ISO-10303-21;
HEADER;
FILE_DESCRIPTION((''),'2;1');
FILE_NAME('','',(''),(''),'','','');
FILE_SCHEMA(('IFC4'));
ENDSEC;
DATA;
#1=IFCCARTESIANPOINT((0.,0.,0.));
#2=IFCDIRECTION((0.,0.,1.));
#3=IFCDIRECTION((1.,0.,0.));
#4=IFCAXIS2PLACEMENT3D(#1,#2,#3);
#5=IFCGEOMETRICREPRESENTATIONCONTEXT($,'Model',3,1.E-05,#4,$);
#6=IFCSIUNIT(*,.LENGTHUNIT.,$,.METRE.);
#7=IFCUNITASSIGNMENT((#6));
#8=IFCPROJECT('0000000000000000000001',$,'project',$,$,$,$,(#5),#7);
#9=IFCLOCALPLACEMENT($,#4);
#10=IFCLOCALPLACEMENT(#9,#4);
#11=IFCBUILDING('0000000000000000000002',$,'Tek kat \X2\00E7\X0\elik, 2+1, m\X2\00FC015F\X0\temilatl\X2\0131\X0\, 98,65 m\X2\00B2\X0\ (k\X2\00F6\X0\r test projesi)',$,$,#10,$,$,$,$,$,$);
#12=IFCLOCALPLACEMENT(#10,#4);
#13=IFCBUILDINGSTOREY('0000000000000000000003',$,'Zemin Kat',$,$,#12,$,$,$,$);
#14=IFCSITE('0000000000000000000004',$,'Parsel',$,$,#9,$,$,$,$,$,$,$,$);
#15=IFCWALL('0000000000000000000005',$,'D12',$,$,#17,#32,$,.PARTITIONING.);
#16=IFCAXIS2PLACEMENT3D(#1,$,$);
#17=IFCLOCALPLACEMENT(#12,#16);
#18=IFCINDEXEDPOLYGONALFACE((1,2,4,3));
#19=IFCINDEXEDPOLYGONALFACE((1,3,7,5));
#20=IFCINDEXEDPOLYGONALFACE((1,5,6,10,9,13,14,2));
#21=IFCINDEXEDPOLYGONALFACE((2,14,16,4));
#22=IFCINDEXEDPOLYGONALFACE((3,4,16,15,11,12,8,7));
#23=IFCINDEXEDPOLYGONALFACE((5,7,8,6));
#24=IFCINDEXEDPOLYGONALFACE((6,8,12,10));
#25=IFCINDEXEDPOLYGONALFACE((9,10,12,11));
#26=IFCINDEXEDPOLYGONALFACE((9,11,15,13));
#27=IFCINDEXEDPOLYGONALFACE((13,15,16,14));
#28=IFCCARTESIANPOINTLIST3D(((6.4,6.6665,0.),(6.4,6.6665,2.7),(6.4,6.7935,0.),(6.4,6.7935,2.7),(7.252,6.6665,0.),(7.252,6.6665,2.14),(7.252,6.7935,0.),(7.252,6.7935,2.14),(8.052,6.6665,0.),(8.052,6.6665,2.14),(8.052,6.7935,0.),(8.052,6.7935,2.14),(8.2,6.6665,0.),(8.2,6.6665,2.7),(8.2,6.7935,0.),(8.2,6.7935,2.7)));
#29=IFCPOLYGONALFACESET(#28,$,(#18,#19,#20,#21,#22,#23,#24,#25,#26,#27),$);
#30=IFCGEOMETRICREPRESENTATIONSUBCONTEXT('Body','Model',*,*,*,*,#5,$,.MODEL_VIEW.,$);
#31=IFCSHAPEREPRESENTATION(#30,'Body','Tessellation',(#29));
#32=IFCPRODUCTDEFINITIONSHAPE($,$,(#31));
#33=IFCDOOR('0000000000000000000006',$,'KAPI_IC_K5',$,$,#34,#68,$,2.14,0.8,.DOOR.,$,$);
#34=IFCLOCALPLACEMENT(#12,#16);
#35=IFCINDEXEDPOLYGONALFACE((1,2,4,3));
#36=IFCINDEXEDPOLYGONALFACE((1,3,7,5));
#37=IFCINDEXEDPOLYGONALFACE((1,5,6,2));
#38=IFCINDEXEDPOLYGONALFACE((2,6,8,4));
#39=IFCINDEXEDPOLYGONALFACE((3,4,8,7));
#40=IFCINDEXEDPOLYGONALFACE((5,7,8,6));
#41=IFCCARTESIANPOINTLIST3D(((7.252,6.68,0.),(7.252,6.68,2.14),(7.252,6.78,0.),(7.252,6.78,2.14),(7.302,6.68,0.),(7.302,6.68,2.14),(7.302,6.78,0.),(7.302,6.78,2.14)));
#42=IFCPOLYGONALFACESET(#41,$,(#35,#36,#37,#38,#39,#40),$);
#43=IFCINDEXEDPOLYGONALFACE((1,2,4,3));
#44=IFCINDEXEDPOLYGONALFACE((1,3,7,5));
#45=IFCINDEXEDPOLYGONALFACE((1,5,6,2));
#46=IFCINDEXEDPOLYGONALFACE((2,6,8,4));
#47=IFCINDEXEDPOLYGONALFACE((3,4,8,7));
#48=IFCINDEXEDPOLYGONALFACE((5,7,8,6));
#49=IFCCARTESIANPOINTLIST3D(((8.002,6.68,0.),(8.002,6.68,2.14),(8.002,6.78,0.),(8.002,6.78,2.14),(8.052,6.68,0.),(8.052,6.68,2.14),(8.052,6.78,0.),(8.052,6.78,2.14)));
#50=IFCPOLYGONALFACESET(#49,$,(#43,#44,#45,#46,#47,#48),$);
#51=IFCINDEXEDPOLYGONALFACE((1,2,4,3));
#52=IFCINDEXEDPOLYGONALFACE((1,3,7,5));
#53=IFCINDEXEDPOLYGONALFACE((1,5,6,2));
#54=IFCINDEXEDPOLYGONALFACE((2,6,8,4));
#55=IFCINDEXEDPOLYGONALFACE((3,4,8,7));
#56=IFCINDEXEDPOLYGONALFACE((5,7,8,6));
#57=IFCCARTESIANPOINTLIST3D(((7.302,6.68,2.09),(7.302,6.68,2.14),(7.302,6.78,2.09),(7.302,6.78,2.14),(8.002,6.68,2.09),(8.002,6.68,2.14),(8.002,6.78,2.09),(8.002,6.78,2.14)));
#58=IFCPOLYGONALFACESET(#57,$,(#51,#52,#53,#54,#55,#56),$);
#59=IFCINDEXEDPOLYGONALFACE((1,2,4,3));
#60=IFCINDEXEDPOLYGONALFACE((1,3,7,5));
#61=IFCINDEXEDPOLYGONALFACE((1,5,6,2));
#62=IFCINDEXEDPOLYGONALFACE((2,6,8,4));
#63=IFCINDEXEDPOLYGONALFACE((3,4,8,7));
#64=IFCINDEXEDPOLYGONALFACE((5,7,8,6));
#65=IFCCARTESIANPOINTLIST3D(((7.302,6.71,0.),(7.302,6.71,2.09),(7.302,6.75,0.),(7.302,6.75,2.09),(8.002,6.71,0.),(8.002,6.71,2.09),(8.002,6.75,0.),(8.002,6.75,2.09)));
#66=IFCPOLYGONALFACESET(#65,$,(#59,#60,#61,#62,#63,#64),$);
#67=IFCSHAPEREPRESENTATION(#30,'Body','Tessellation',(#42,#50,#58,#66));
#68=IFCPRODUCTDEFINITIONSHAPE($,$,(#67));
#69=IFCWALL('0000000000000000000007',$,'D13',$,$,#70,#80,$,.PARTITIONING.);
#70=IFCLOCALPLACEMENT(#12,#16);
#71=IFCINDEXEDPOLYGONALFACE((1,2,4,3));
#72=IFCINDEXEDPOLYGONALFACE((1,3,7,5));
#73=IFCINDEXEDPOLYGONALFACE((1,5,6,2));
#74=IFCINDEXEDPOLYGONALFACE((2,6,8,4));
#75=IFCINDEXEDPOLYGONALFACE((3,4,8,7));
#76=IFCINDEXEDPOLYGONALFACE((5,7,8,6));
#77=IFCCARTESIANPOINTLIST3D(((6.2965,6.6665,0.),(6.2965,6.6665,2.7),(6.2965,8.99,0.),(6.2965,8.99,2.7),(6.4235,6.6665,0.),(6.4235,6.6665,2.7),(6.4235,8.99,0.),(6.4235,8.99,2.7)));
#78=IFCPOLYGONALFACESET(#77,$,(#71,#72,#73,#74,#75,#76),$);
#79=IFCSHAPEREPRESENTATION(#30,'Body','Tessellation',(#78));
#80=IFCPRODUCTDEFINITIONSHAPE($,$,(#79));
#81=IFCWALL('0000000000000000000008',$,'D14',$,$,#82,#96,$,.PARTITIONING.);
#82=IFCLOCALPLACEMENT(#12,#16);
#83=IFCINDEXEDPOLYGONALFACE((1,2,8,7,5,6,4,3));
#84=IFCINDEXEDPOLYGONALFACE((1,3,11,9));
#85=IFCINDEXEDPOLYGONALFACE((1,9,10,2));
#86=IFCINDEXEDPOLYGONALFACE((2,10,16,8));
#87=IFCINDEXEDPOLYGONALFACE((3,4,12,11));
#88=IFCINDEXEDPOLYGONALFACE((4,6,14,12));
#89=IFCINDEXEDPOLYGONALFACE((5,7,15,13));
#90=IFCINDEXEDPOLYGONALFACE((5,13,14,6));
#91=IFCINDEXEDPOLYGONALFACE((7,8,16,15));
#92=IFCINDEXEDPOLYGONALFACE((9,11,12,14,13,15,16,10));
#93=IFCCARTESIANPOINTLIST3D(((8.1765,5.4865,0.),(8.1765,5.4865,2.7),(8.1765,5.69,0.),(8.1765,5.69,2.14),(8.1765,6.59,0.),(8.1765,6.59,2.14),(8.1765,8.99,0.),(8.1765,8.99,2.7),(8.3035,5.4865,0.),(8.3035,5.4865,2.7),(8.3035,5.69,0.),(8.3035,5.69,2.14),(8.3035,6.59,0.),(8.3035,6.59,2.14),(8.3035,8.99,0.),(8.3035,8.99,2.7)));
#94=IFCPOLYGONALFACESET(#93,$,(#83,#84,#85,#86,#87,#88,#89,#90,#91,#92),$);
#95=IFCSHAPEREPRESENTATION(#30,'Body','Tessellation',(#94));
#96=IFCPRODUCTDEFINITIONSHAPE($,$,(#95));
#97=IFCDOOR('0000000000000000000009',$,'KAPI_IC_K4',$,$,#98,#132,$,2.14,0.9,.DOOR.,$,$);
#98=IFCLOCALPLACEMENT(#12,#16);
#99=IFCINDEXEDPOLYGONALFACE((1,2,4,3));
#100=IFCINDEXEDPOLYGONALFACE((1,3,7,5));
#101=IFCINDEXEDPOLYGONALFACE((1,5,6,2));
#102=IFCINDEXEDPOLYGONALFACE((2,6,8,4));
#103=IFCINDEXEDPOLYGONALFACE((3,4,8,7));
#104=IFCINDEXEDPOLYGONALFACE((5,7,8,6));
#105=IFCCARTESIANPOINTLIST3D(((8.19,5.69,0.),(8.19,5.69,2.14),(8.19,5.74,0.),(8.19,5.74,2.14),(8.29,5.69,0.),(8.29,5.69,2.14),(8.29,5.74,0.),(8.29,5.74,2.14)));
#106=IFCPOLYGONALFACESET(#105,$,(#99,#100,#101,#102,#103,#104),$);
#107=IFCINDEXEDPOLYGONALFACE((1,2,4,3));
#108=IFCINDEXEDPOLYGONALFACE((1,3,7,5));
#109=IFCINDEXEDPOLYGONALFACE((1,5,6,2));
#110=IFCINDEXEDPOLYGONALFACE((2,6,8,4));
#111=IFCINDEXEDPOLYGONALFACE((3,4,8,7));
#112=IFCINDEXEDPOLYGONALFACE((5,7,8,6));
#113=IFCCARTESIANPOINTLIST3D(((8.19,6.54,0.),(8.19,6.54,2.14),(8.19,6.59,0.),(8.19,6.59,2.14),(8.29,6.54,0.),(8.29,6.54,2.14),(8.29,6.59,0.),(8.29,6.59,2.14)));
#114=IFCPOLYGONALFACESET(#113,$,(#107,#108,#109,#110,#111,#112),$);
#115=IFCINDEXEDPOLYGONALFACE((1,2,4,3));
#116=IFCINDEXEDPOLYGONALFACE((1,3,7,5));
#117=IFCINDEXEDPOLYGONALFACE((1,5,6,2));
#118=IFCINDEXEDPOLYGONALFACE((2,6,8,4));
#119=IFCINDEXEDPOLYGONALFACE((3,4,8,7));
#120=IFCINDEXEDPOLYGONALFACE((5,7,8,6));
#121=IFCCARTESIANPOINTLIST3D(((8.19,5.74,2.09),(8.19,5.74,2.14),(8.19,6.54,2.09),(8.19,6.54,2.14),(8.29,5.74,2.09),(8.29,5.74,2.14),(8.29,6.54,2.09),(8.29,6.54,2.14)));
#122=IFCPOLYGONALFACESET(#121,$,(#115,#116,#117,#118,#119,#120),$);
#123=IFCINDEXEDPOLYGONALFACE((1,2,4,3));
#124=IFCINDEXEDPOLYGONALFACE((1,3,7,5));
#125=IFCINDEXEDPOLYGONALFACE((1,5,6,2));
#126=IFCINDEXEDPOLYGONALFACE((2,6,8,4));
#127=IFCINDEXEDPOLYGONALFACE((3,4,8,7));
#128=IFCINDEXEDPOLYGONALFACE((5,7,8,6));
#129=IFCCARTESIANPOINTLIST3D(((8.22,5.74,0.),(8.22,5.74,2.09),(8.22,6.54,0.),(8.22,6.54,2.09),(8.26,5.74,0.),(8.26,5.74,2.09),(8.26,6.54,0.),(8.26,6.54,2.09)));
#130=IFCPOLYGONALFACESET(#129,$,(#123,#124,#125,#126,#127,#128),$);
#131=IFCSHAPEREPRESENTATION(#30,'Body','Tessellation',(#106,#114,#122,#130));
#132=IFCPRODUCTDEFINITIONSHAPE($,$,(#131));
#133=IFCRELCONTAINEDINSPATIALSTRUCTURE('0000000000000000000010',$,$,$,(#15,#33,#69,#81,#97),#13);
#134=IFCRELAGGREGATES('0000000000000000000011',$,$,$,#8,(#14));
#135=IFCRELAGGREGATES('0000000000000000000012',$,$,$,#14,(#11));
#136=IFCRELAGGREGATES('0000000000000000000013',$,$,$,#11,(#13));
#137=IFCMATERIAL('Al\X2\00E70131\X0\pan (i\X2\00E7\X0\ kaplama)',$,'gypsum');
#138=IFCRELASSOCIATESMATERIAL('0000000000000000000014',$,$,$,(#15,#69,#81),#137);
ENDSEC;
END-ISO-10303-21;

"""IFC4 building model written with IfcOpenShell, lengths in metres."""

from ifc_helpers import new_model, si_unit, frame, origin_with_axes, place, context, subcontext, project, spatial, line, indexed_curve, outline, extrude, material, element, fill, save


model = new_model("IFC4")

# Units and contexts
model_context = context("Model", 3, precision=1e-05, world=origin_with_axes())
body_context = subcontext(model_context, "Body", "Model", "MODEL_VIEW")
ifc_project = project(units=[si_unit("LENGTHUNIT", "METRE")], contexts=[model_context])

# Site, building, storey
site_placement = place(None, origin_with_axes())
site = spatial("IfcSite", under=ifc_project, at=site_placement, Name="Parsel")
building_placement = place(site_placement, origin_with_axes())
building = spatial("IfcBuilding", under=site, at=building_placement, Name="Tek kat çelik, 2+1, müştemilatlı, 98,65 m² (kör test projesi)")
storey_placement = place(building_placement, origin_with_axes())
storey = spatial("IfcBuildingStorey", under=building, at=storey_placement, Name="Zemin Kat")

# Shared definitions
ifc_material_1 = material(Name="Alçıpan (iç kaplama)", Category="gypsum")

# Wall, opening, door
wall_1_placement = place(storey_placement, origin_with_axes())
wall_1 = element("IfcWall", 1, at=wall_1_placement, inside=storey, material=ifc_material_1, Name="D12", PredefinedType="PARTITIONING", context=body_context, shape_type="SweptSolid", body=[
    extrude(outline(indexed_curve([(0.0, 0.0), (1.8, 0.0), (1.8, 0.127), (0.0, 0.127)], segments=[line(1, 2, 3, 4, 1)])), frame((6.4, 6.6665, 0.0), z_axis=(0.0, 0.0, 1.0), x_axis=(1.0, 0.0, 0.0)), (0.0, 0.0, 1.0), 2.7),
])
opening_1_placement = place(wall_1_placement, origin_with_axes())
opening_1 = element("IfcOpeningElement", 2, at=opening_1_placement, cuts=wall_1, PredefinedType="OPENING", context=body_context, shape_type="SweptSolid", body=[
    extrude(outline(indexed_curve([(0.0, 0.0), (0.8, 0.0), (0.8, 0.167), (0.0, 0.167)], segments=[line(1, 2, 3, 4, 1)])), frame((7.252, 6.6465, 0.0), z_axis=(0.0, 0.0, 1.0), x_axis=(1.0, 0.0, 0.0)), (0.0, 0.0, 1.0), 2.14),
])
door_1_placement = place(storey_placement, origin_with_axes())
door_1 = element("IfcDoor", 3, at=door_1_placement, inside=storey, Name="KAPI_IC_K5", OverallHeight=2.14, OverallWidth=0.8, PredefinedType="DOOR", context=body_context, shape_type="SweptSolid", body=[
    extrude(outline(indexed_curve([(0.0, 0.0), (0.05, 0.0), (0.05, 0.1), (0.0, 0.1)], segments=[line(1, 2, 3, 4, 1)])), frame((7.252, 6.68, 0.0), z_axis=(0.0, 0.0, 1.0), x_axis=(1.0, 0.0, 0.0)), (0.0, 0.0, 1.0), 2.14),
    extrude(outline(indexed_curve([(0.0, 0.0), (0.05, 0.0), (0.05, 0.1), (0.0, 0.1)], segments=[line(1, 2, 3, 4, 1)])), frame((8.002, 6.68, 0.0), z_axis=(0.0, 0.0, 1.0), x_axis=(1.0, 0.0, 0.0)), (0.0, 0.0, 1.0), 2.14),
    extrude(outline(indexed_curve([(0.0, 0.0), (0.7, 0.0), (0.7, 0.1), (0.0, 0.1)], segments=[line(1, 2, 3, 4, 1)])), frame((7.302, 6.68, 2.09), z_axis=(0.0, 0.0, 1.0), x_axis=(1.0, 0.0, 0.0)), (0.0, 0.0, 1.0), 0.05),
    extrude(outline(indexed_curve([(0.0, 0.0), (0.7, 0.0), (0.7, 0.04), (0.0, 0.04)], segments=[line(1, 2, 3, 4, 1)])), frame((7.302, 6.71, 0.0), z_axis=(0.0, 0.0, 1.0), x_axis=(1.0, 0.0, 0.0)), (0.0, 0.0, 1.0), 2.09),
])
fill(opening_1, door_1)

# Wall
wall_2_placement = place(storey_placement, origin_with_axes())
element("IfcWall", 4, at=wall_2_placement, inside=storey, material=ifc_material_1, Name="D13", PredefinedType="PARTITIONING", context=body_context, shape_type="SweptSolid", body=[
    extrude(outline(indexed_curve([(0.0, 0.0), (0.127, 0.0), (0.127, 2.3235), (0.0, 2.3235)], segments=[line(1, 2, 3, 4, 1)])), frame((6.2965, 6.6665, 0.0), z_axis=(0.0, 0.0, 1.0), x_axis=(1.0, 0.0, 0.0)), (0.0, 0.0, 1.0), 2.7),
])

# Wall, opening, door
wall_3_placement = place(storey_placement, origin_with_axes())
wall_3 = element("IfcWall", 5, at=wall_3_placement, inside=storey, material=ifc_material_1, Name="D14", PredefinedType="PARTITIONING", context=body_context, shape_type="SweptSolid", body=[
    extrude(outline(indexed_curve([(0.0, 0.0), (0.127, 0.0), (0.127, 3.5035), (0.0, 3.5035)], segments=[line(1, 2, 3, 4, 1)])), frame((8.1765, 5.4865, 0.0), z_axis=(0.0, 0.0, 1.0), x_axis=(1.0, 0.0, 0.0)), (0.0, 0.0, 1.0), 2.7),
])
opening_2_placement = place(wall_3_placement, origin_with_axes())
opening_2 = element("IfcOpeningElement", 6, at=opening_2_placement, cuts=wall_3, PredefinedType="OPENING", context=body_context, shape_type="SweptSolid", body=[
    extrude(outline(indexed_curve([(0.0, 0.0), (0.167, 0.0), (0.167, 0.9), (0.0, 0.9)], segments=[line(1, 2, 3, 4, 1)])), frame((8.1565, 5.69, 0.0), z_axis=(0.0, 0.0, 1.0), x_axis=(1.0, 0.0, 0.0)), (0.0, 0.0, 1.0), 2.14),
])
door_2_placement = place(storey_placement, origin_with_axes())
door_2 = element("IfcDoor", 7, at=door_2_placement, inside=storey, Name="KAPI_IC_K4", OverallHeight=2.14, OverallWidth=0.9, PredefinedType="DOOR", context=body_context, shape_type="SweptSolid", body=[
    extrude(outline(indexed_curve([(0.0, 0.0), (0.1, 0.0), (0.1, 0.05), (0.0, 0.05)], segments=[line(1, 2, 3, 4, 1)])), frame((8.19, 5.69, 0.0), z_axis=(0.0, 0.0, 1.0), x_axis=(1.0, 0.0, 0.0)), (0.0, 0.0, 1.0), 2.14),
    extrude(outline(indexed_curve([(0.0, 0.0), (0.1, 0.0), (0.1, 0.05), (0.0, 0.05)], segments=[line(1, 2, 3, 4, 1)])), frame((8.19, 6.54, 0.0), z_axis=(0.0, 0.0, 1.0), x_axis=(1.0, 0.0, 0.0)), (0.0, 0.0, 1.0), 2.14),
    extrude(outline(indexed_curve([(0.0, 0.0), (0.1, 0.0), (0.1, 0.8), (0.0, 0.8)], segments=[line(1, 2, 3, 4, 1)])), frame((8.19, 5.74, 2.09), z_axis=(0.0, 0.0, 1.0), x_axis=(1.0, 0.0, 0.0)), (0.0, 0.0, 1.0), 0.05),
    extrude(outline(indexed_curve([(0.0, 0.0), (0.04, 0.0), (0.04, 0.8), (0.0, 0.8)], segments=[line(1, 2, 3, 4, 1)])), frame((8.22, 5.74, 0.0), z_axis=(0.0, 0.0, 1.0), x_axis=(1.0, 0.0, 0.0)), (0.0, 0.0, 1.0), 2.09),
])
fill(opening_2, door_2)

save(model, "model.ifc")
